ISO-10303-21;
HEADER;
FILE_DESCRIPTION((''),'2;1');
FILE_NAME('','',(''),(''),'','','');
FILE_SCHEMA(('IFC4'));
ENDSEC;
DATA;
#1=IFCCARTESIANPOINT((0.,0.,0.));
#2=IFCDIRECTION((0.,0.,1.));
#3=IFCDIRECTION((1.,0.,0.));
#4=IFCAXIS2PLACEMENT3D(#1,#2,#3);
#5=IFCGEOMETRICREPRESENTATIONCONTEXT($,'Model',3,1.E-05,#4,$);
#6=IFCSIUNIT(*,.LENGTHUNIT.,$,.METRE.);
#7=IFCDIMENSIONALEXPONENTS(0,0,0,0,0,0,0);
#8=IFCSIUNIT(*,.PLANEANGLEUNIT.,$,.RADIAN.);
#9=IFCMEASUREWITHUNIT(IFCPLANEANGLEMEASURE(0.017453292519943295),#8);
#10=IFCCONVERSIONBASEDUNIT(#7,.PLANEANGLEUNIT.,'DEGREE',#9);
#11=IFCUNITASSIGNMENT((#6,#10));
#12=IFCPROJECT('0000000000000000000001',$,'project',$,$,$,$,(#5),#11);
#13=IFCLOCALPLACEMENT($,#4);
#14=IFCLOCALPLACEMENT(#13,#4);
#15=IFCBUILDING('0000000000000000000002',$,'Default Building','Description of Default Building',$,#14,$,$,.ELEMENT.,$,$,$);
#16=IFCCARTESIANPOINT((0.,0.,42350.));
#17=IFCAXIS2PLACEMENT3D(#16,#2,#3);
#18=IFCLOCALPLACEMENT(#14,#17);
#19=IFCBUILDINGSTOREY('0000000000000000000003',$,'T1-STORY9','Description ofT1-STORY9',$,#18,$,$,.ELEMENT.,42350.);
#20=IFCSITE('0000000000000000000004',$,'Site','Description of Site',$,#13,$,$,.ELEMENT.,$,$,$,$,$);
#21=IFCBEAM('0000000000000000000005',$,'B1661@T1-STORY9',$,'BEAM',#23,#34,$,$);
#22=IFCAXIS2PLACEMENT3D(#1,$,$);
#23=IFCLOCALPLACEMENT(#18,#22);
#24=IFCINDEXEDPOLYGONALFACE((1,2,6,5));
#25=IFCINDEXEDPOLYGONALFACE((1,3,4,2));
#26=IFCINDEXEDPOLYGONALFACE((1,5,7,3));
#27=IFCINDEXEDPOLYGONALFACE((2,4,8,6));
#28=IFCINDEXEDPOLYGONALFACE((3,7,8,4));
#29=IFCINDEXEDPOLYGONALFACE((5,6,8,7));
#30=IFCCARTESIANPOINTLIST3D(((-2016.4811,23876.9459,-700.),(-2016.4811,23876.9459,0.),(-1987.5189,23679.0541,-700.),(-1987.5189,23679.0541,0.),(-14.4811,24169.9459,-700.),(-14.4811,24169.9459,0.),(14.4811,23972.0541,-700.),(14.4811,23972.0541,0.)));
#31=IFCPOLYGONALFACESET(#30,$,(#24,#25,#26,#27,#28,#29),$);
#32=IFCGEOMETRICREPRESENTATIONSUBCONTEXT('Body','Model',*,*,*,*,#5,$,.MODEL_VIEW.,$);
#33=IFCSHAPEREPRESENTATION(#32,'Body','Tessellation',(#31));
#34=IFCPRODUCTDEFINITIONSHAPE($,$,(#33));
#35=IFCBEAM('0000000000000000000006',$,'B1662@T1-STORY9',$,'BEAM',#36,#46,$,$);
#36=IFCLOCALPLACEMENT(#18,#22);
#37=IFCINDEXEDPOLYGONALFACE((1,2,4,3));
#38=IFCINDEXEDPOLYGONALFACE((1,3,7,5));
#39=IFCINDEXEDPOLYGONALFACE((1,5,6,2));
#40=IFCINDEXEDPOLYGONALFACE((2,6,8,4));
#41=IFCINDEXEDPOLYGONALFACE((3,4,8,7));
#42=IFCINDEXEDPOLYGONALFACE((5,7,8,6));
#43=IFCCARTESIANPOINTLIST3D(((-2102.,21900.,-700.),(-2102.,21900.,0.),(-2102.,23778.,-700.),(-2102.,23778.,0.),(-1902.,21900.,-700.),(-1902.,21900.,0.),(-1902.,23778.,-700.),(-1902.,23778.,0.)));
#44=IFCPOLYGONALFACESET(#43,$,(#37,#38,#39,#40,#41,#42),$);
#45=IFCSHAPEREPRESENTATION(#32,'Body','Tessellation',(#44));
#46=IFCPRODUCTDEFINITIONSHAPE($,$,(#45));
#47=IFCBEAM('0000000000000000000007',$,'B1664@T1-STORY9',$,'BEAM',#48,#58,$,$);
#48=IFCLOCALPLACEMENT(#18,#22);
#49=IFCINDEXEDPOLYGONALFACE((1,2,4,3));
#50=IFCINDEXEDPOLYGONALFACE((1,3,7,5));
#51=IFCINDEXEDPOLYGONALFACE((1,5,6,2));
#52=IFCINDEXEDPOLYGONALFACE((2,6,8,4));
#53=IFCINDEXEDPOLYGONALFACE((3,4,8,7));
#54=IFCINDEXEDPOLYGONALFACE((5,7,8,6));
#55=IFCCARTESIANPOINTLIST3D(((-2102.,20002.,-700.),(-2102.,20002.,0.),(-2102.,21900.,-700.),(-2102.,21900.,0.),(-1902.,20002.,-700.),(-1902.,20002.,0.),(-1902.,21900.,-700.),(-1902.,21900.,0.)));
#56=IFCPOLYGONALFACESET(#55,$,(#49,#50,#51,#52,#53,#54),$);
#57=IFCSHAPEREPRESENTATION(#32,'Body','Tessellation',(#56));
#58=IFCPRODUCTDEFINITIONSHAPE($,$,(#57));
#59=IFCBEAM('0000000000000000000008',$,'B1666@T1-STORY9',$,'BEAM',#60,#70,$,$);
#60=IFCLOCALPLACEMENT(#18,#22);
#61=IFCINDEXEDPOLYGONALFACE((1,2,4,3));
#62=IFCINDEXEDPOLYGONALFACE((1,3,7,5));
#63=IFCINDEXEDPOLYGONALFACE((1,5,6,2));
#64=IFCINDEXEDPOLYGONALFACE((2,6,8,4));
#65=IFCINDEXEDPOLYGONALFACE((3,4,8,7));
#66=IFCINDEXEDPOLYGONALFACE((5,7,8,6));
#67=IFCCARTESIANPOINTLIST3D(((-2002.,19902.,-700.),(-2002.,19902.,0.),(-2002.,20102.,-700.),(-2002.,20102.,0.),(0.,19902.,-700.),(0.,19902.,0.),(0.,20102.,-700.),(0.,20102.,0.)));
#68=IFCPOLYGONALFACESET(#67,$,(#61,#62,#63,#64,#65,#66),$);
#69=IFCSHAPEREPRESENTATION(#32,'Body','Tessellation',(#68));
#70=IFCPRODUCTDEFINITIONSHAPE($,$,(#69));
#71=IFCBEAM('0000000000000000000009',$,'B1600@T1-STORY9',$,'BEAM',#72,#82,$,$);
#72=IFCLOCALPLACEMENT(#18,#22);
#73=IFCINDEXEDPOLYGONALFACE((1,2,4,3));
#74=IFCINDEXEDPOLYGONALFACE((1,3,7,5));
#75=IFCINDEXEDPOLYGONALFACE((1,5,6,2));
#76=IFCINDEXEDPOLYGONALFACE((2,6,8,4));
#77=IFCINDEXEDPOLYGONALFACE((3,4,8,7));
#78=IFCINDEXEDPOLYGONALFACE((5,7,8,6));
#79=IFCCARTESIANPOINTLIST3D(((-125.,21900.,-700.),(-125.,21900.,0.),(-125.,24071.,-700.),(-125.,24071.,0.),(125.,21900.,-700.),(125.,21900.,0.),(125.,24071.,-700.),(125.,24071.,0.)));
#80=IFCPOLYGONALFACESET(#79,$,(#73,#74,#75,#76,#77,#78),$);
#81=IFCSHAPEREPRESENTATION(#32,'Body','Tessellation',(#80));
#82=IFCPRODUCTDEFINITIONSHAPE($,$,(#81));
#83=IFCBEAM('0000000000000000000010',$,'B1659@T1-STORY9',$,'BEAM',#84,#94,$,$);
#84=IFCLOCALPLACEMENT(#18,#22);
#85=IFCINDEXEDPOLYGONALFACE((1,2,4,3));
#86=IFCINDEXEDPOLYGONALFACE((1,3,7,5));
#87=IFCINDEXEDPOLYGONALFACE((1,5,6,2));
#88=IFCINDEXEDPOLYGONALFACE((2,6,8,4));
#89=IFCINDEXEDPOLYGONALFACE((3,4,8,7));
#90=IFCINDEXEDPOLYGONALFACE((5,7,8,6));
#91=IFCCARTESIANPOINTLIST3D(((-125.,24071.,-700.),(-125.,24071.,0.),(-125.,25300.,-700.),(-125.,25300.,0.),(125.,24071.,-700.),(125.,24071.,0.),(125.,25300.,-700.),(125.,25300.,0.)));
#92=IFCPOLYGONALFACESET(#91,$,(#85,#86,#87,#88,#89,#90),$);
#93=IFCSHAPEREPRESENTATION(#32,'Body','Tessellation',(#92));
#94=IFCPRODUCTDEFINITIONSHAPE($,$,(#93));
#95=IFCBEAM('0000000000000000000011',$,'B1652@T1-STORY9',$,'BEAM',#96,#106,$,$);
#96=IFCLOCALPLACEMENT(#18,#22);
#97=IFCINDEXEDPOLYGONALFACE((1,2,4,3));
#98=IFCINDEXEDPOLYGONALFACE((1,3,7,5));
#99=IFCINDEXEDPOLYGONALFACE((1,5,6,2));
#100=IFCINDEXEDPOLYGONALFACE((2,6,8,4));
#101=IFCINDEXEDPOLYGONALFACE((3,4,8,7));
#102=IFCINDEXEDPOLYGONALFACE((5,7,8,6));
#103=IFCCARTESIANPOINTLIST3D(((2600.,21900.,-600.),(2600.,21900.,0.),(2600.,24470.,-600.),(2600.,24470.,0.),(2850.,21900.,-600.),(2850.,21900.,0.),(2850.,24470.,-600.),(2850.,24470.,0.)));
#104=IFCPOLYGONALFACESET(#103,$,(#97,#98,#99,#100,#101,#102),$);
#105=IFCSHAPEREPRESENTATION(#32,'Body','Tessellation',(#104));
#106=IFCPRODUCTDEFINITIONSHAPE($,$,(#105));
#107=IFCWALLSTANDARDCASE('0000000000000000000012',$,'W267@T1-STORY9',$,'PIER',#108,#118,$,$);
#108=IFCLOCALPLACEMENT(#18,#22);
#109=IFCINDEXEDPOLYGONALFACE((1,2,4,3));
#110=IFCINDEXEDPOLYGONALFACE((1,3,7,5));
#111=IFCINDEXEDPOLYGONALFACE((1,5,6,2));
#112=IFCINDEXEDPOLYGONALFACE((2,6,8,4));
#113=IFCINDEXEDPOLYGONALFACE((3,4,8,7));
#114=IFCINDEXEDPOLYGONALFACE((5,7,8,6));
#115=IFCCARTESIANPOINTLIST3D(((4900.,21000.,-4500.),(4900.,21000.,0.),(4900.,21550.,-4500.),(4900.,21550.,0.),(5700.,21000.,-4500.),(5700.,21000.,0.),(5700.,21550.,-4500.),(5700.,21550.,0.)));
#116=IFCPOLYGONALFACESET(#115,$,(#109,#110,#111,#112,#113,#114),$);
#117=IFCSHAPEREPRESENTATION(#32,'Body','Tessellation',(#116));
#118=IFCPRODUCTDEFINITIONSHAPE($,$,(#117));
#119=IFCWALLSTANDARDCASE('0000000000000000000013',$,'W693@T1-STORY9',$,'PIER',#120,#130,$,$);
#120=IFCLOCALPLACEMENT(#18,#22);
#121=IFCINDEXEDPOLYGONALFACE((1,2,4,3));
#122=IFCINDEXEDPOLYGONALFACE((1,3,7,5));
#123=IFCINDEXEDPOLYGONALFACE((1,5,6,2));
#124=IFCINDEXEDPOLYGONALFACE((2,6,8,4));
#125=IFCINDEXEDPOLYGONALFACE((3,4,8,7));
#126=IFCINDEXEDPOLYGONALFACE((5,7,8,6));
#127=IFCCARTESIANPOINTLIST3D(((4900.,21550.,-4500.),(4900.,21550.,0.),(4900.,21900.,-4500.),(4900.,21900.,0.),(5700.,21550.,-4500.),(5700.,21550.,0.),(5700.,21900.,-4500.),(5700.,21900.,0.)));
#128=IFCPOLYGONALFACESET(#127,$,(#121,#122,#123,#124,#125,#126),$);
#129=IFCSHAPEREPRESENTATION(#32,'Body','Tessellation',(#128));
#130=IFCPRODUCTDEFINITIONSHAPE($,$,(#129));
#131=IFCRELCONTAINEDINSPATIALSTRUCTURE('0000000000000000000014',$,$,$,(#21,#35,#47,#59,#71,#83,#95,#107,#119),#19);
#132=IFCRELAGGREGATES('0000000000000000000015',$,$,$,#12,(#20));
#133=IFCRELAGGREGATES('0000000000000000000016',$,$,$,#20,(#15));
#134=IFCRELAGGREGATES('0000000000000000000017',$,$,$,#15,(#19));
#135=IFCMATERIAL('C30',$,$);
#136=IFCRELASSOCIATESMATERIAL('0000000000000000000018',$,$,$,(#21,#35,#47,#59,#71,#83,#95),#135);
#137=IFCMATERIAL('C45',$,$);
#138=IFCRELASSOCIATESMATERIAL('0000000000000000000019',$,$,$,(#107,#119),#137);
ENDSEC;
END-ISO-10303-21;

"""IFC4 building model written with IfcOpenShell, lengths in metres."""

from ifc_helpers import new_model, entity, si_unit, converted_unit, frame, origin_with_axes, place, context, subcontext, project, spatial, indexed_curve, rectangle, outline, extrude, material, element, save


model = new_model("IFC4")

# Units and contexts
model_context = context("Model", 3, precision=1e-05, world=origin_with_axes())
body_context = subcontext(model_context, "Body", "Model", "MODEL_VIEW")
ifc_project = project(units=[si_unit("LENGTHUNIT", "METRE"), converted_unit("PLANEANGLEUNIT", "DEGREE", entity("IfcPlaneAngleMeasure", 0.017453292519943295), si_unit("PLANEANGLEUNIT", "RADIAN"), dimensions=[0, 0, 0, 0, 0, 0, 0])], contexts=[model_context])

# Site, building, storey
site_placement = place(None, origin_with_axes())
site = spatial("IfcSite", under=ifc_project, at=site_placement, Name="Site", Description="Description of Site", CompositionType="ELEMENT")
building_placement = place(site_placement, origin_with_axes())
building = spatial("IfcBuilding", under=site, at=building_placement, Name="Default Building", Description="Description of Default Building", CompositionType="ELEMENT")
storey_placement = place(building_placement, frame((0.0, 0.0, 42350.0), z_axis=(0.0, 0.0, 1.0), x_axis=(1.0, 0.0, 0.0)))
storey = spatial("IfcBuildingStorey", under=building, at=storey_placement, Name="T1-STORY9", Description="Description ofT1-STORY9", CompositionType="ELEMENT", Elevation=42350.0)

# Beams
ifc_material_1 = material(Name="C30")
beam_1_placement = place(storey_placement, frame((-2002.0, 23778.0, -350.0), z_axis=(0.989459, 0.144811, 0.0), x_axis=(-0.144811, 0.989459, 0.0)))
element("IfcBeam", 1, at=beam_1_placement, inside=storey, material=ifc_material_1, Name="B1661@T1-STORY9", ObjectType="BEAM", context=body_context, shape_type="SweptSolid", body=[
    extrude(rectangle(XDim=200.0, YDim=700.0), origin_with_axes(), (0.0, 0.0, 1.0), 2023.3272),
])
beam_2_placement = place(storey_placement, frame((-2002.0, 21900.0, -350.0), z_axis=(0.0, 1.0, 0.0), x_axis=(-1.0, 0.0, 0.0)))
element("IfcBeam", 2, at=beam_2_placement, inside=storey, material=ifc_material_1, Name="B1662@T1-STORY9", ObjectType="BEAM", context=body_context, shape_type="SweptSolid", body=[
    extrude(rectangle(XDim=200.0, YDim=700.0), origin_with_axes(), (0.0, 0.0, 1.0), 1878.0),
])
beam_3_placement = place(storey_placement, frame((-2002.0, 20002.0, -350.0), z_axis=(0.0, 1.0, 0.0), x_axis=(-1.0, 0.0, 0.0)))
element("IfcBeam", 3, at=beam_3_placement, inside=storey, material=ifc_material_1, Name="B1664@T1-STORY9", ObjectType="BEAM", context=body_context, shape_type="SweptSolid", body=[
    extrude(rectangle(XDim=200.0, YDim=700.0), origin_with_axes(), (0.0, 0.0, 1.0), 1898.0),
])
beam_4_placement = place(storey_placement, frame((-2002.0, 20002.0, -350.0), z_axis=(1.0, 0.0, 0.0), x_axis=(0.0, 1.0, 0.0)))
element("IfcBeam", 4, at=beam_4_placement, inside=storey, material=ifc_material_1, Name="B1666@T1-STORY9", ObjectType="BEAM", context=body_context, shape_type="SweptSolid", body=[
    extrude(rectangle(XDim=200.0, YDim=700.0), origin_with_axes(), (0.0, 0.0, 1.0), 2002.0),
])
beam_5_placement = place(storey_placement, frame((0.0, 21900.0, -350.0), z_axis=(0.0, 1.0, 0.0), x_axis=(-1.0, 0.0, 0.0)))
element("IfcBeam", 5, at=beam_5_placement, inside=storey, material=ifc_material_1, Name="B1600@T1-STORY9", ObjectType="BEAM", context=body_context, shape_type="SweptSolid", body=[
    extrude(rectangle(XDim=250.0, YDim=700.0), origin_with_axes(), (0.0, 0.0, 1.0), 2171.0),
])
beam_6_placement = place(storey_placement, frame((0.0, 24071.0, -350.0), z_axis=(0.0, 1.0, 0.0), x_axis=(-1.0, 0.0, 0.0)))
element("IfcBeam", 6, at=beam_6_placement, inside=storey, material=ifc_material_1, Name="B1659@T1-STORY9", ObjectType="BEAM", context=body_context, shape_type="SweptSolid", body=[
    extrude(rectangle(XDim=250.0, YDim=700.0), origin_with_axes(), (0.0, 0.0, 1.0), 1229.0),
])
beam_7_placement = place(storey_placement, frame((2725.0, 21900.0, -300.0), z_axis=(0.0, 1.0, 0.0), x_axis=(-1.0, 0.0, 0.0)))
element("IfcBeam", 7, at=beam_7_placement, inside=storey, material=ifc_material_1, Name="B1652@T1-STORY9", ObjectType="BEAM", context=body_context, shape_type="SweptSolid", body=[
    extrude(rectangle(XDim=250.0, YDim=600.0), origin_with_axes(), (0.0, 0.0, 1.0), 2570.0),
])
ifc_material_2 = material(Name="C45")

# Walls
wall_1_placement = place(storey_placement, frame((5300.0, 21000.0, -4500.0), z_axis=(0.0, 0.0, 1.0), x_axis=(0.0, 1.0, 0.0)))
element("IfcWallStandardCase", 8, at=wall_1_placement, inside=storey, material=ifc_material_2, Name="W267@T1-STORY9", ObjectType="PIER", context=body_context, shape_type="SweptSolid", body=[
    extrude(outline(indexed_curve([(0.0, -400.0), (0.0, 400.0), (550.0, 400.0), (550.0, -400.0), (0.0, -400.0)], self_intersect=False)), origin_with_axes(), (0.0, 0.0, 1.0), 4500.0),
])
wall_2_placement = place(storey_placement, frame((5300.0, 21550.0, -4500.0), z_axis=(0.0, 0.0, 1.0), x_axis=(0.0, 1.0, 0.0)))
element("IfcWallStandardCase", 9, at=wall_2_placement, inside=storey, material=ifc_material_2, Name="W693@T1-STORY9", ObjectType="PIER", context=body_context, shape_type="SweptSolid", body=[
    extrude(outline(indexed_curve([(0.0, -400.0), (0.0, 400.0), (350.0, 400.0), (350.0, -400.0), (0.0, -400.0)], self_intersect=False)), origin_with_axes(), (0.0, 0.0, 1.0), 4500.0),
])

save(model, "model.ifc")
